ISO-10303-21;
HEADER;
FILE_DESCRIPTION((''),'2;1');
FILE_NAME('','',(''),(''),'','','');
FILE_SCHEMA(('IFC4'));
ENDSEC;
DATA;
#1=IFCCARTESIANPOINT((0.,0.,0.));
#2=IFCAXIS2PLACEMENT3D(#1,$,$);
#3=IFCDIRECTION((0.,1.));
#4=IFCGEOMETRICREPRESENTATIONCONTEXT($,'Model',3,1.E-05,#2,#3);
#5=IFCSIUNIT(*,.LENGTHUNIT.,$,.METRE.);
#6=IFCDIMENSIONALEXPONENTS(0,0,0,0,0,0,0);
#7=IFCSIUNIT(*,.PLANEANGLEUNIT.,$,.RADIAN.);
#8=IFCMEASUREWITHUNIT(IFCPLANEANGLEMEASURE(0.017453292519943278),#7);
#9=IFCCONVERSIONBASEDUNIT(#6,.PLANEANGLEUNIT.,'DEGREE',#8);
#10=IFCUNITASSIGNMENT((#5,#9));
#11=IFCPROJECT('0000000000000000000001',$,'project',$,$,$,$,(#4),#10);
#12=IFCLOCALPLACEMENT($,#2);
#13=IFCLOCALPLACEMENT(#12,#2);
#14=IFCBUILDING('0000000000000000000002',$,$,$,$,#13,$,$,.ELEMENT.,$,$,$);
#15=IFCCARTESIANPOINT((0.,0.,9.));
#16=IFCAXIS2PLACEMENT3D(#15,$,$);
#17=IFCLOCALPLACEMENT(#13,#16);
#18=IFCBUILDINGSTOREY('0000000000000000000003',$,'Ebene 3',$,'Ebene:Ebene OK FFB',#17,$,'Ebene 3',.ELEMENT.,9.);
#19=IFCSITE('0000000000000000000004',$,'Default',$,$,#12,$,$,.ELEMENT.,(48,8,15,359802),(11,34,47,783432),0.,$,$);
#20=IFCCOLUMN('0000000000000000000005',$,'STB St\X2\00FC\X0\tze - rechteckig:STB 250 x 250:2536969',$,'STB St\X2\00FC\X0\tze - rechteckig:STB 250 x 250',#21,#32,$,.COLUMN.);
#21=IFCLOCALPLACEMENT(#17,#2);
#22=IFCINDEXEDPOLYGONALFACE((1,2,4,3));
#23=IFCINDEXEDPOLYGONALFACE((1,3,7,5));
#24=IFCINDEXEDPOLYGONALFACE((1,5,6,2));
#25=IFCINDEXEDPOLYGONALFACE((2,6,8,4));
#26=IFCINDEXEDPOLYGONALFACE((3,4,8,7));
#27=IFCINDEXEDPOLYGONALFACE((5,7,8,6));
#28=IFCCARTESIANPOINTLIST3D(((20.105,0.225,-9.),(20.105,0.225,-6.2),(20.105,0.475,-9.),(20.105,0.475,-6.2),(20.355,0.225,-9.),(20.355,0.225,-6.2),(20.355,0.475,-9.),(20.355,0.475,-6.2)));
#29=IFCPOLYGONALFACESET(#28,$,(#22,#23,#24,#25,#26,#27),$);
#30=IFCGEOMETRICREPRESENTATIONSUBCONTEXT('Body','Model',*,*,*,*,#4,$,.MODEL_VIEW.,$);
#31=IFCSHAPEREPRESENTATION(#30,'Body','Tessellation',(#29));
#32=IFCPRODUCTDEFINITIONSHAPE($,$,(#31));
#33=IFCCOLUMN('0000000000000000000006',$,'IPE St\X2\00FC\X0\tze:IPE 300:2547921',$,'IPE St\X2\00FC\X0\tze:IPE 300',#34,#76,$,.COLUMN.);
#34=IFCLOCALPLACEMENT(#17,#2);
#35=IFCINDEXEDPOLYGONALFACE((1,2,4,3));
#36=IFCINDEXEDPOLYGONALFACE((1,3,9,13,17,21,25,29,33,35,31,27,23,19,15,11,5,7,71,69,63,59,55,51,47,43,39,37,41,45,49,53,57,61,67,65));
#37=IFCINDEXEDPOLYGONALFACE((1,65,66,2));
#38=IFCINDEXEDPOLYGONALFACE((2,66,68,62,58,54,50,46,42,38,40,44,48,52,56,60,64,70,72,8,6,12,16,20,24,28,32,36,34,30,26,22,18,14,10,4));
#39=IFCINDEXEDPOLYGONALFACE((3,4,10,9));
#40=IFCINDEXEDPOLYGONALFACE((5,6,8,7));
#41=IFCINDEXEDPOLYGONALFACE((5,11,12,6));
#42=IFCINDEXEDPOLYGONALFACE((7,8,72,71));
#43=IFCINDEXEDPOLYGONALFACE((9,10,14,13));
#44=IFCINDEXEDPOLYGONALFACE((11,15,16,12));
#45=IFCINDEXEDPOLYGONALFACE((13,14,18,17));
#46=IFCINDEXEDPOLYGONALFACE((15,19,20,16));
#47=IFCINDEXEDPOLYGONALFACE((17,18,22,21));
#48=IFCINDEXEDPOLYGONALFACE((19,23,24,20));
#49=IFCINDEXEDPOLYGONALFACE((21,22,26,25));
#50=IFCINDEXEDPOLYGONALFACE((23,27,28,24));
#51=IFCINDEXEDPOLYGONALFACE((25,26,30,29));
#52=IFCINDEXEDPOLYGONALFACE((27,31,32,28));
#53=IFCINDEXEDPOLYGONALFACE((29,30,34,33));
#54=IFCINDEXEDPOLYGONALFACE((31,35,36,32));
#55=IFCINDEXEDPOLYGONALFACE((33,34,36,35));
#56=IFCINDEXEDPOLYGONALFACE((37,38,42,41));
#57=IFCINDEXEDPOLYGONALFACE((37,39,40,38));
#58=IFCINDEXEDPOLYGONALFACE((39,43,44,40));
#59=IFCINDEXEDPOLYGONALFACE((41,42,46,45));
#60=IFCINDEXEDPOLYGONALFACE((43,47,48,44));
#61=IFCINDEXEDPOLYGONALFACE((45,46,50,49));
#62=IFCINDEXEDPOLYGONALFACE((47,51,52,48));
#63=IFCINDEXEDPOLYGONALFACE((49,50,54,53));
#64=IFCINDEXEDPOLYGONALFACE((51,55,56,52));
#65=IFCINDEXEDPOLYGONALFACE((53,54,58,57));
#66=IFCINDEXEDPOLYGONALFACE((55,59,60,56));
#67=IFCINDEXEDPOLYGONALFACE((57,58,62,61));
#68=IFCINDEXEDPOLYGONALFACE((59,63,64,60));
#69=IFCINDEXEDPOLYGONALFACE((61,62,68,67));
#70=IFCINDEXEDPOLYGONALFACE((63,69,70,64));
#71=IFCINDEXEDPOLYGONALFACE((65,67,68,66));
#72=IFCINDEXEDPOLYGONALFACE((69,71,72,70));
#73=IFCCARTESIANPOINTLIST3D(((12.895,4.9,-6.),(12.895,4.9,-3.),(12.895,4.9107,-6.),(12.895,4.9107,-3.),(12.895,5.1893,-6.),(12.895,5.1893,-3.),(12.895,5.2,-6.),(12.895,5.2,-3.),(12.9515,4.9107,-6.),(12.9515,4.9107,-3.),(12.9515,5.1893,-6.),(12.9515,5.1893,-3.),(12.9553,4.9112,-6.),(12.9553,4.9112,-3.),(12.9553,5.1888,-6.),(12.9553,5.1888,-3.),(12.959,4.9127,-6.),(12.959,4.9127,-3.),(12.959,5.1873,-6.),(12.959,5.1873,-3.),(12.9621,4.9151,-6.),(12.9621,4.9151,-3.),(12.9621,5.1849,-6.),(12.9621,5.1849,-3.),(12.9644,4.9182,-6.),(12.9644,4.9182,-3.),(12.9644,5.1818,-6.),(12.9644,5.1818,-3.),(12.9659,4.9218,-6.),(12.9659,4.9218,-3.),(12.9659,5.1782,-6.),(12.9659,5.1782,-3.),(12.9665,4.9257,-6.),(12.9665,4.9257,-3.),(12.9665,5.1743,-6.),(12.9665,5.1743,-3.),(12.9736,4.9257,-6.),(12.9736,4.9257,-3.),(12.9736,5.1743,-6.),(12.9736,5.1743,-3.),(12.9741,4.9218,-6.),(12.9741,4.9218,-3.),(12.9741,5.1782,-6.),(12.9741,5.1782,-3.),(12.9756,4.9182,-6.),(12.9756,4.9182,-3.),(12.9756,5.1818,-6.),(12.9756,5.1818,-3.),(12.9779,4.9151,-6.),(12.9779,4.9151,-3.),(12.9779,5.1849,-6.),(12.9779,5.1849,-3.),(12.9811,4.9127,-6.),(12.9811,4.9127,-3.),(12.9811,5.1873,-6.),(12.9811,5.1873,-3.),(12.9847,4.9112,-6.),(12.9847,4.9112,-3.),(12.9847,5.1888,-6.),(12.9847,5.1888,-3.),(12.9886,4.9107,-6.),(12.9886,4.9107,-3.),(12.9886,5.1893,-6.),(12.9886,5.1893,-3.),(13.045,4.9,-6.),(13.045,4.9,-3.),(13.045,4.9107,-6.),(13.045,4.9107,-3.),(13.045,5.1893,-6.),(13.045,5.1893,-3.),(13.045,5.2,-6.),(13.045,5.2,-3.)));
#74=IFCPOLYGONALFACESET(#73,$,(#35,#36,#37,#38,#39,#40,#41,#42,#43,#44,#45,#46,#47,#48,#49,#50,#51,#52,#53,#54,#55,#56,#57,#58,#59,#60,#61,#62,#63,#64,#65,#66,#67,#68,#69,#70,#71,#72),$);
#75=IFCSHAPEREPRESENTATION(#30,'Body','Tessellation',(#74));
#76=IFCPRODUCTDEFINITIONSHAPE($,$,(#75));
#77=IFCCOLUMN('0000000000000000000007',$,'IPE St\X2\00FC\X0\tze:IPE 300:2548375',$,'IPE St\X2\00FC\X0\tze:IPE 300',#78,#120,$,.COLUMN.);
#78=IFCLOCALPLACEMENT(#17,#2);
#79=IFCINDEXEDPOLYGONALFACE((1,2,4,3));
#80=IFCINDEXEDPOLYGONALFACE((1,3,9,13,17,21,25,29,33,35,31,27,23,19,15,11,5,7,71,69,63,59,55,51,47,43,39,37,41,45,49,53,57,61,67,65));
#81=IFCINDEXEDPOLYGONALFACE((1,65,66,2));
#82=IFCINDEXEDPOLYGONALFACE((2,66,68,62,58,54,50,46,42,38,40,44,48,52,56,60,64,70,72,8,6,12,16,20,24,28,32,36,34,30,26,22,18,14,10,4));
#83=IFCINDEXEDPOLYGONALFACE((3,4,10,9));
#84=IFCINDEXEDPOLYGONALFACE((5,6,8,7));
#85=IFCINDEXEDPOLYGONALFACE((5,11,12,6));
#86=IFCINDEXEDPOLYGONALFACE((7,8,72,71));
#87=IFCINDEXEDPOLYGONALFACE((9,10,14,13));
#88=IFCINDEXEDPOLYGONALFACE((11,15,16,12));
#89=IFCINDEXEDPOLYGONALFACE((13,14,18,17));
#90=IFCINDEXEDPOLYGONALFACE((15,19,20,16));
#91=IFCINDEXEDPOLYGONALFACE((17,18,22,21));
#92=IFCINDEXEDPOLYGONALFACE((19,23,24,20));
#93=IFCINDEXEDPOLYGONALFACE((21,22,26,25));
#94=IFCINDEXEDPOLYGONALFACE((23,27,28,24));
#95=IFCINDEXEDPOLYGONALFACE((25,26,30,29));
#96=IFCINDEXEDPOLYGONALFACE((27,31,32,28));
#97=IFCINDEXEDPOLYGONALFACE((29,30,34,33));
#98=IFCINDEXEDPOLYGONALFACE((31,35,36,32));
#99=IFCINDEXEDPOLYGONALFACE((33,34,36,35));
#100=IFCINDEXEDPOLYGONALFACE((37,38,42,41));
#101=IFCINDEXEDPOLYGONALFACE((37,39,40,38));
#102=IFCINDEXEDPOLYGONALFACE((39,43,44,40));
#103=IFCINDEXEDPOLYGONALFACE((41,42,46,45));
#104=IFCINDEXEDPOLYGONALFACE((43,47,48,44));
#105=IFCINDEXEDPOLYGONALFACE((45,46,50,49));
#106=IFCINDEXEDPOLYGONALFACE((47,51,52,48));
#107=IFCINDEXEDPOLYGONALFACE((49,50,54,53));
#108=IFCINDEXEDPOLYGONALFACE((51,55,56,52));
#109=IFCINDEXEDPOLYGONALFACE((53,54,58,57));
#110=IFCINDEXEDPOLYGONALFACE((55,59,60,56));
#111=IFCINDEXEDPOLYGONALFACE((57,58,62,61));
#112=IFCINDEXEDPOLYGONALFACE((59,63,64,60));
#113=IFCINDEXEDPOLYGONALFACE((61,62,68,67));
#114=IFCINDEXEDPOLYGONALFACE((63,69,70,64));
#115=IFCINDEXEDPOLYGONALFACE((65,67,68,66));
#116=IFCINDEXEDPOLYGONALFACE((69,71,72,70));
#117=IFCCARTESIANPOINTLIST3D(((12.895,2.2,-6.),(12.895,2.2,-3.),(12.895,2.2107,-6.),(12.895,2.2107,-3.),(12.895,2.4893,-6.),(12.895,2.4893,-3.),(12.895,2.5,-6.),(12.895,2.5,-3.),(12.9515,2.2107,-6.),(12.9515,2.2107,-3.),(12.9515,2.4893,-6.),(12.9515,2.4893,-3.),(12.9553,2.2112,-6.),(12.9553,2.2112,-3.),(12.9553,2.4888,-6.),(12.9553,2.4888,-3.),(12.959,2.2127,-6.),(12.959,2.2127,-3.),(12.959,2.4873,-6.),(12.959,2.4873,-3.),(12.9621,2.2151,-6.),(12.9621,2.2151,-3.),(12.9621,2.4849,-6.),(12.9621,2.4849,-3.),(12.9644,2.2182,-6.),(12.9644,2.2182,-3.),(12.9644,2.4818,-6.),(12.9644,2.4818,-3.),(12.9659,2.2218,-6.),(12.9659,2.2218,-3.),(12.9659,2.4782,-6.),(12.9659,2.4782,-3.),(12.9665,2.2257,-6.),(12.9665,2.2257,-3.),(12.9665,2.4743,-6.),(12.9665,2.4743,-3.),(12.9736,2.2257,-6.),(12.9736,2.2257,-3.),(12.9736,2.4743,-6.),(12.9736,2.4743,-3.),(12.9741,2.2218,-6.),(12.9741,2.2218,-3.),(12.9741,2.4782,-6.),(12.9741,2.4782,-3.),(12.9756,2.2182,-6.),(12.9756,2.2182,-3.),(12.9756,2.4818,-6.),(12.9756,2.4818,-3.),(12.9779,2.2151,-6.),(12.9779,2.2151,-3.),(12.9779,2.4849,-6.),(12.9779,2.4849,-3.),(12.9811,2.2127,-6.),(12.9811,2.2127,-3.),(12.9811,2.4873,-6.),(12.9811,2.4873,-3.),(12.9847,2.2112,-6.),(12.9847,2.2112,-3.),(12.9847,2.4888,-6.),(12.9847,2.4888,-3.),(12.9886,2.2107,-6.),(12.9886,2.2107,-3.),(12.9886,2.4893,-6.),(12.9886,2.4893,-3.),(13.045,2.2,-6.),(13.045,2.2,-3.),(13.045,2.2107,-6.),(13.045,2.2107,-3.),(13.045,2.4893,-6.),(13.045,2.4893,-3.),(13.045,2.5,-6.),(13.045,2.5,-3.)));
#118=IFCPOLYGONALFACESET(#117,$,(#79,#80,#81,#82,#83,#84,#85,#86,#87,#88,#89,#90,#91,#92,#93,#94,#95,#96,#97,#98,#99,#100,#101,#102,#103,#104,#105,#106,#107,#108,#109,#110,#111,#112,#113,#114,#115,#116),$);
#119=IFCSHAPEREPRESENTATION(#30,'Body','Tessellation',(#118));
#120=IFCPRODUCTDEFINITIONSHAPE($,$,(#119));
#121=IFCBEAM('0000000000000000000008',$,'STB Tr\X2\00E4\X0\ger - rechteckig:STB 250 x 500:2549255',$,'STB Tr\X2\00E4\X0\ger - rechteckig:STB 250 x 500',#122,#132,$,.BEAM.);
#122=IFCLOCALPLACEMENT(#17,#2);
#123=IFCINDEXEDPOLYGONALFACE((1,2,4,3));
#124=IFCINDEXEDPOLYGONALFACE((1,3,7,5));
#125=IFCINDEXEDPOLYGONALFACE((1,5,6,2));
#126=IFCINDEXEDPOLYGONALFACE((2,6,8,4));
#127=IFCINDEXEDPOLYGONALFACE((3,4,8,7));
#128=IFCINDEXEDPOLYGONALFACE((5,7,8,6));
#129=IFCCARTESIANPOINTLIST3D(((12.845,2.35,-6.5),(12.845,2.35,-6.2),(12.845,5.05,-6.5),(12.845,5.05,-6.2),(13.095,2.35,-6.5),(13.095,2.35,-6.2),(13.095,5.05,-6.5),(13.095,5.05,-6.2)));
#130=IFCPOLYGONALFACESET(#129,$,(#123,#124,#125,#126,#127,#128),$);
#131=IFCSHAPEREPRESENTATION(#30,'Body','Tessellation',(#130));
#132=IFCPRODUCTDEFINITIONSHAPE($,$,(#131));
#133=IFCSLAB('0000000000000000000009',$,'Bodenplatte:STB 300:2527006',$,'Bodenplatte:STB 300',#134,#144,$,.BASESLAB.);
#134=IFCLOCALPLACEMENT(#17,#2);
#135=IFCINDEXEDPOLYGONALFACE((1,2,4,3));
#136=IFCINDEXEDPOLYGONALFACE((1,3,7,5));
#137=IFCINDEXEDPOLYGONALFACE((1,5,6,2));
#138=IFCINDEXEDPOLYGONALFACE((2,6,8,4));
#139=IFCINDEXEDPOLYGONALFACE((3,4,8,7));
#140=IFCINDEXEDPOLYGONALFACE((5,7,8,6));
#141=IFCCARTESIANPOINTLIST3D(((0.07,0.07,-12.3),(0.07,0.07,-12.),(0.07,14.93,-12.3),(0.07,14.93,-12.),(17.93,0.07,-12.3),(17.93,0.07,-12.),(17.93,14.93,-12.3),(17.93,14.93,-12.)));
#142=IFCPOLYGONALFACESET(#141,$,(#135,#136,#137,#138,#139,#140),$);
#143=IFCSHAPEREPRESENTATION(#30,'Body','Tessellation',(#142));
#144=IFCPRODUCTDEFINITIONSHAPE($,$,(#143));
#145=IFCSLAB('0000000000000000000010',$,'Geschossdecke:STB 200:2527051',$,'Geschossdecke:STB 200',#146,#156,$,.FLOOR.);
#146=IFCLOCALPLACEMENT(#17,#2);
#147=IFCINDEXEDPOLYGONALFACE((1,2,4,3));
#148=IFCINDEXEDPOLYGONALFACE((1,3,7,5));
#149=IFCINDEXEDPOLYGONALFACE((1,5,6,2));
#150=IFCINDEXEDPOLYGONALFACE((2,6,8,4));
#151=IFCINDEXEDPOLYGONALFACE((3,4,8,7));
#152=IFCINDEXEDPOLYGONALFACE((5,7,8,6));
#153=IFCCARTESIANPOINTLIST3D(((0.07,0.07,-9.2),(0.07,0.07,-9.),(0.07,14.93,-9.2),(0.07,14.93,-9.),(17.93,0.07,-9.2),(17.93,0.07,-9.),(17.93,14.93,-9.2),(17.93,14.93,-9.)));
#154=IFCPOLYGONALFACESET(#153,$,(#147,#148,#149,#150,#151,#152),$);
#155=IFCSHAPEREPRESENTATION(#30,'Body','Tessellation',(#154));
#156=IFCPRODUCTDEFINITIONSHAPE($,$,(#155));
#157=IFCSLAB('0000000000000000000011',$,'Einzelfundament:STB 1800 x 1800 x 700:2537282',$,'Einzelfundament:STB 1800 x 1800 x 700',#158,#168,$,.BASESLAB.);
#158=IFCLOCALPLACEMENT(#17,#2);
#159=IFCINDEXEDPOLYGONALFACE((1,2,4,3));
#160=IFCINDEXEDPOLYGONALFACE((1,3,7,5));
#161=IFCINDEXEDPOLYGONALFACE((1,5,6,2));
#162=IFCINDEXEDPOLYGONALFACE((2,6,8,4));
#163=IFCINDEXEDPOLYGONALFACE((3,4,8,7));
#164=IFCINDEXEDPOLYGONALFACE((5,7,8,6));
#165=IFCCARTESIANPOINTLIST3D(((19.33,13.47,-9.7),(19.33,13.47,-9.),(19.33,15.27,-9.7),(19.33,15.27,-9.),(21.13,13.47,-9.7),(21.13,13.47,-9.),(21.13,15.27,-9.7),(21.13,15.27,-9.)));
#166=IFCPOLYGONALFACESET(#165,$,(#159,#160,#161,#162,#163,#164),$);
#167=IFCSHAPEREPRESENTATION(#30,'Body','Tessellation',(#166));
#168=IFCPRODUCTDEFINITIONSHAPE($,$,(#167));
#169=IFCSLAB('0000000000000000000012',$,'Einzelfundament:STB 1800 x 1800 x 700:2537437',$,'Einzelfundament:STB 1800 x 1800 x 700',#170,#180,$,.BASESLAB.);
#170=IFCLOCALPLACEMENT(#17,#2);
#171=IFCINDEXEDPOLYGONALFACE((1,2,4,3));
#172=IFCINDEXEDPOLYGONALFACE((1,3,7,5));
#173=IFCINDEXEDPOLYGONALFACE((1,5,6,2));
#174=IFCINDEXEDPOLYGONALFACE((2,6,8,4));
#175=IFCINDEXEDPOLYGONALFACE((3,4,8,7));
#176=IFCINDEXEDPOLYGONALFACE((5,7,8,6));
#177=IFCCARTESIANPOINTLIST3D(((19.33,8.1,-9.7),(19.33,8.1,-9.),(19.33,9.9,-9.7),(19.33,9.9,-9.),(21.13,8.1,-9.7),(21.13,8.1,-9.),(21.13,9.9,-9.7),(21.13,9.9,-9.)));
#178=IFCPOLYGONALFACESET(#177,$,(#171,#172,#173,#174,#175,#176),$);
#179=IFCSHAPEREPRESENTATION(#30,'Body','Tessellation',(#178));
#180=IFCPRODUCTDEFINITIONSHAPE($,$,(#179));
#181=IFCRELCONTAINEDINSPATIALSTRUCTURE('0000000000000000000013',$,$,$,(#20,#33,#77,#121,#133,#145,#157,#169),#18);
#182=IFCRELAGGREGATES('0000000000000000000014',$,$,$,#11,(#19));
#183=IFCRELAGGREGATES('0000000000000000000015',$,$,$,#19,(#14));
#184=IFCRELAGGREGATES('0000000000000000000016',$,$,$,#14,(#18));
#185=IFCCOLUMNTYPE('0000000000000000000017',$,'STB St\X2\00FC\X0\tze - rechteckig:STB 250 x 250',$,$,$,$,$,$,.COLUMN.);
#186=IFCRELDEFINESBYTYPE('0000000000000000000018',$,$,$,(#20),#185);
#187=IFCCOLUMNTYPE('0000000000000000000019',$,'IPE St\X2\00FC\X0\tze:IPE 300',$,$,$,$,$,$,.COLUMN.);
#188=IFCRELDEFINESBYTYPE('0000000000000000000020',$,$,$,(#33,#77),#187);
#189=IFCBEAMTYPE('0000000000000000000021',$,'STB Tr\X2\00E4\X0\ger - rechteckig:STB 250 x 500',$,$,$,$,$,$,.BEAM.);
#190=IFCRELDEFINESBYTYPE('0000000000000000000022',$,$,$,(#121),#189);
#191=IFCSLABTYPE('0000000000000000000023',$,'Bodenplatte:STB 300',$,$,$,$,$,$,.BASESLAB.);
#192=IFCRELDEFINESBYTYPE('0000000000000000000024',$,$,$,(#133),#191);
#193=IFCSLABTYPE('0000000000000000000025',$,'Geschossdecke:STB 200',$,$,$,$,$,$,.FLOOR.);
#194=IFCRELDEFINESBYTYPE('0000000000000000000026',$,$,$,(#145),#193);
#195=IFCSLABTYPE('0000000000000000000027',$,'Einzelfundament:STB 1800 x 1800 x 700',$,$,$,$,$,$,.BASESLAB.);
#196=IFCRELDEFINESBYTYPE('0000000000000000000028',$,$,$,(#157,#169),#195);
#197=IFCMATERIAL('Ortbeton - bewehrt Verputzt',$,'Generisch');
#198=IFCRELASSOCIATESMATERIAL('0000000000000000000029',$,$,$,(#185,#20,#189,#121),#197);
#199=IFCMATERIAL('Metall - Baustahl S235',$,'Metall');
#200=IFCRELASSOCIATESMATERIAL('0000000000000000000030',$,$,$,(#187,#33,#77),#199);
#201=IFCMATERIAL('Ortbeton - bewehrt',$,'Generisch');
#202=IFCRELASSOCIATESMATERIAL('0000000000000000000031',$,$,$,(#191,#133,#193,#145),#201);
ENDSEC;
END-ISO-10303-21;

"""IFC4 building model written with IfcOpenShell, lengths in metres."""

from ifc_helpers import new_model, entity, si_unit, converted_unit, direction, frame, origin, place, context, subcontext, project, spatial, line, arc, indexed_curve, outline, extrude, source, transform, mapped, material, type_object, type_shapes, element, save


model = new_model("IFC4")

# Units and contexts
model_context = context("Model", 3, precision=1e-05, world=origin(), true_north=direction((0.0, 1.0)))
body_context = subcontext(model_context, "Body", "Model", "MODEL_VIEW")
ifc_project = project(units=[si_unit("LENGTHUNIT", "METRE"), converted_unit("PLANEANGLEUNIT", "DEGREE", entity("IfcPlaneAngleMeasure", 0.017453292519943278), si_unit("PLANEANGLEUNIT", "RADIAN"), dimensions=[0, 0, 0, 0, 0, 0, 0])], contexts=[model_context])

# Site, building, storey
site_placement = place(None, origin())
site = spatial("IfcSite", under=ifc_project, at=site_placement, Name="Default", CompositionType="ELEMENT", RefLatitude=(48, 8, 15, 359802), RefLongitude=(11, 34, 47, 783432), RefElevation=0.0)
building_placement = place(site_placement, origin())
building = spatial("IfcBuilding", under=site, at=building_placement, CompositionType="ELEMENT")
storey_placement = place(building_placement, frame((0.0, 0.0, 9.0)))
storey = spatial("IfcBuildingStorey", under=building, at=storey_placement, Name="Ebene 3", ObjectType="Ebene:Ebene OK FFB", LongName="Ebene 3", CompositionType="ELEMENT", Elevation=9.0)

# Columns
ifc_material_1 = material(Name="Ortbeton - bewehrt Verputzt", Category="Generisch")
column_type_1 = type_object("IfcColumnType", Name="STB Stütze - rechteckig:STB 250 x 250", PredefinedType="COLUMN", material=ifc_material_1)
shared_shape_1 = source(origin(), body_context, "Body", "SweptSolid", [
    extrude(outline(indexed_curve([(-0.125, -0.125), (0.125, -0.125), (0.125, 0.125), (-0.125, 0.125), (-0.125, -0.125)], self_intersect=False)), frame((20.23, 0.35, 0.0), z_axis=(0.0, 0.0, 1.0), x_axis=(-1.0, 0.0, 0.0)), (0.0, 0.0, 1.0), 2.8),
])
type_shapes(column_type_1, [shared_shape_1])
column_1_placement = place(storey_placement, frame((0.0, 0.0, -9.0)))
element("IfcColumn", 1, at=column_1_placement, inside=storey, type_object=column_type_1, material=ifc_material_1, Name="STB Stütze - rechteckig:STB 250 x 250:2536969", ObjectType="STB Stütze - rechteckig:STB 250 x 250", PredefinedType="COLUMN", context=body_context, shape_type="MappedRepresentation", body=[
    mapped(shared_shape_1, transform((0.0, 0.0, 0.0), scale=1.0)),
])
ifc_material_2 = material(Name="Metall - Baustahl S235", Category="Metall")
column_type_2 = type_object("IfcColumnType", Name="IPE Stütze:IPE 300", PredefinedType="COLUMN", material=ifc_material_2)
shared_shape_2 = source(origin(), body_context, "Body", "SweptSolid", [
    extrude(outline(indexed_curve([(-0.075, -0.15), (0.075, -0.15), (0.075, -0.1393), (0.0186, -0.1393), (0.0079, -0.1349), (0.0035, -0.1243), (0.0035, 0.1243), (0.0079, 0.1349), (0.0185, 0.1393), (0.075, 0.1393), (0.075, 0.15), (-0.075, 0.15), (-0.075, 0.1393), (-0.0186, 0.1393), (-0.0079, 0.1349), (-0.0035, 0.1243), (-0.0036, -0.1243), (-0.0079, -0.1349), (-0.0186, -0.1393), (-0.075, -0.1393)], segments=[line(1, 2, 3, 4), arc(4, 5, 6), line(6, 7), arc(7, 8, 9), line(9, 10, 11, 12, 13, 14), arc(14, 15, 16), line(16, 17), arc(17, 18, 19), line(19, 20, 1)], self_intersect=False)), frame((0.0, 0.0, 3.0), z_axis=(0.0, 0.0, 1.0), x_axis=(-1.0, 0.0, 0.0)), (0.0, 0.0, 1.0), 3.0),
])
type_shapes(column_type_2, [shared_shape_2])
for number, where, name in (
    (2, (12.97, 5.05, -9.0), "IPE Stütze:IPE 300:2547921"),
    (3, (12.97, 2.35, -9.0), "IPE Stütze:IPE 300:2548375"),
):
    element("IfcColumn", number, at=place(storey_placement, frame(where)), inside=storey, type_object=column_type_2, material=ifc_material_2, Name=name, ObjectType="IPE Stütze:IPE 300", PredefinedType="COLUMN", context=body_context, shape_type="MappedRepresentation", body=[
        mapped(shared_shape_2, transform((0.0, 0.0, 0.0), scale=1.0)),
    ])

# Beam
beam_type = type_object("IfcBeamType", Name="STB Träger - rechteckig:STB 250 x 500", PredefinedType="BEAM", material=ifc_material_1)
shared_shape_3 = source(origin(), body_context, "Body", "SweptSolid", [
    extrude(outline(indexed_curve([(-0.125, -0.15), (0.125, -0.15), (0.125, 0.15), (-0.125, 0.15), (-0.125, -0.15)], self_intersect=False)), frame((12.97, 5.05, 2.65), z_axis=(0.0, -1.0, 0.0), x_axis=(-1.0, 0.0, 0.0)), (0.0, 0.0, 1.0), 2.7),
])
type_shapes(beam_type, [shared_shape_3])
beam_placement = place(storey_placement, frame((0.0, 0.0, -9.0)))
element("IfcBeam", 4, at=beam_placement, inside=storey, type_object=beam_type, material=ifc_material_1, Name="STB Träger - rechteckig:STB 250 x 500:2549255", ObjectType="STB Träger - rechteckig:STB 250 x 500", PredefinedType="BEAM", context=body_context, shape_type="MappedRepresentation", body=[
    mapped(shared_shape_3, transform((0.0, 0.0, 0.0), scale=1.0)),
])

# Slabs
ifc_material_3 = material(Name="Ortbeton - bewehrt", Category="Generisch")
slab_type_1 = type_object("IfcSlabType", Name="Bodenplatte:STB 300", PredefinedType="BASESLAB", material=ifc_material_3)
slab_1_placement = place(storey_placement, origin())
element("IfcSlab", 5, at=slab_1_placement, inside=storey, type_object=slab_type_1, material=ifc_material_3, Name="Bodenplatte:STB 300:2527006", ObjectType="Bodenplatte:STB 300", PredefinedType="BASESLAB", context=body_context, shape_type="SweptSolid", body=[
    extrude(outline(indexed_curve([(-7.43, -8.93), (7.43, -8.93), (7.43, 8.93), (-7.43, 8.93), (-7.43, -8.93)], self_intersect=False)), frame((9.0, 7.5, -12.0), z_axis=(0.0, 0.0, -1.0), x_axis=(0.0, 1.0, 0.0)), (0.0, 0.0, 1.0), 0.3),
])
slab_type_2 = type_object("IfcSlabType", Name="Geschossdecke:STB 200", PredefinedType="FLOOR", material=ifc_material_3)
slab_2_placement = place(storey_placement, origin())
element("IfcSlab", 6, at=slab_2_placement, inside=storey, type_object=slab_type_2, material=ifc_material_3, Name="Geschossdecke:STB 200:2527051", ObjectType="Geschossdecke:STB 200", PredefinedType="FLOOR", context=body_context, shape_type="SweptSolid", body=[
    extrude(outline(indexed_curve([(-7.43, -8.93), (7.43, -8.93), (7.43, 8.93), (-7.43, 8.93), (-7.43, -8.93)], self_intersect=False)), frame((9.0, 7.5, -9.0), z_axis=(0.0, 0.0, -1.0), x_axis=(0.0, 1.0, 0.0)), (0.0, 0.0, 1.0), 0.2),
])

# Slabs
slab_type_3 = type_object("IfcSlabType", Name="Einzelfundament:STB 1800 x 1800 x 700", PredefinedType="BASESLAB")
slab_3_placement = place(storey_placement, origin())
element("IfcSlab", 7, at=slab_3_placement, inside=storey, type_object=slab_type_3, Name="Einzelfundament:STB 1800 x 1800 x 700:2537282", ObjectType="Einzelfundament:STB 1800 x 1800 x 700", PredefinedType="BASESLAB", context=body_context, shape_type="SweptSolid", body=[
    extrude(outline(indexed_curve([(-0.9, -0.9), (0.9, -0.9), (0.9, 0.9), (-0.9, 0.9), (-0.9, -0.9)], self_intersect=False)), frame((20.23, 14.37, -9.7), z_axis=(0.0, 0.0, 1.0), x_axis=(-1.0, 0.0, 0.0)), (0.0, 0.0, 1.0), 0.7),
])
slab_4_placement = place(storey_placement, origin())
element("IfcSlab", 8, at=slab_4_placement, inside=storey, type_object=slab_type_3, Name="Einzelfundament:STB 1800 x 1800 x 700:2537437", ObjectType="Einzelfundament:STB 1800 x 1800 x 700", PredefinedType="BASESLAB", context=body_context, shape_type="SweptSolid", body=[
    extrude(outline(indexed_curve([(-0.9, -0.9), (0.9, -0.9), (0.9, 0.9), (-0.9, 0.9), (-0.9, -0.9)], self_intersect=False)), frame((20.23, 9.0, -9.7), z_axis=(0.0, 0.0, 1.0), x_axis=(-1.0, 0.0, 0.0)), (0.0, 0.0, 1.0), 0.7),
])

save(model, "model.ifc")
